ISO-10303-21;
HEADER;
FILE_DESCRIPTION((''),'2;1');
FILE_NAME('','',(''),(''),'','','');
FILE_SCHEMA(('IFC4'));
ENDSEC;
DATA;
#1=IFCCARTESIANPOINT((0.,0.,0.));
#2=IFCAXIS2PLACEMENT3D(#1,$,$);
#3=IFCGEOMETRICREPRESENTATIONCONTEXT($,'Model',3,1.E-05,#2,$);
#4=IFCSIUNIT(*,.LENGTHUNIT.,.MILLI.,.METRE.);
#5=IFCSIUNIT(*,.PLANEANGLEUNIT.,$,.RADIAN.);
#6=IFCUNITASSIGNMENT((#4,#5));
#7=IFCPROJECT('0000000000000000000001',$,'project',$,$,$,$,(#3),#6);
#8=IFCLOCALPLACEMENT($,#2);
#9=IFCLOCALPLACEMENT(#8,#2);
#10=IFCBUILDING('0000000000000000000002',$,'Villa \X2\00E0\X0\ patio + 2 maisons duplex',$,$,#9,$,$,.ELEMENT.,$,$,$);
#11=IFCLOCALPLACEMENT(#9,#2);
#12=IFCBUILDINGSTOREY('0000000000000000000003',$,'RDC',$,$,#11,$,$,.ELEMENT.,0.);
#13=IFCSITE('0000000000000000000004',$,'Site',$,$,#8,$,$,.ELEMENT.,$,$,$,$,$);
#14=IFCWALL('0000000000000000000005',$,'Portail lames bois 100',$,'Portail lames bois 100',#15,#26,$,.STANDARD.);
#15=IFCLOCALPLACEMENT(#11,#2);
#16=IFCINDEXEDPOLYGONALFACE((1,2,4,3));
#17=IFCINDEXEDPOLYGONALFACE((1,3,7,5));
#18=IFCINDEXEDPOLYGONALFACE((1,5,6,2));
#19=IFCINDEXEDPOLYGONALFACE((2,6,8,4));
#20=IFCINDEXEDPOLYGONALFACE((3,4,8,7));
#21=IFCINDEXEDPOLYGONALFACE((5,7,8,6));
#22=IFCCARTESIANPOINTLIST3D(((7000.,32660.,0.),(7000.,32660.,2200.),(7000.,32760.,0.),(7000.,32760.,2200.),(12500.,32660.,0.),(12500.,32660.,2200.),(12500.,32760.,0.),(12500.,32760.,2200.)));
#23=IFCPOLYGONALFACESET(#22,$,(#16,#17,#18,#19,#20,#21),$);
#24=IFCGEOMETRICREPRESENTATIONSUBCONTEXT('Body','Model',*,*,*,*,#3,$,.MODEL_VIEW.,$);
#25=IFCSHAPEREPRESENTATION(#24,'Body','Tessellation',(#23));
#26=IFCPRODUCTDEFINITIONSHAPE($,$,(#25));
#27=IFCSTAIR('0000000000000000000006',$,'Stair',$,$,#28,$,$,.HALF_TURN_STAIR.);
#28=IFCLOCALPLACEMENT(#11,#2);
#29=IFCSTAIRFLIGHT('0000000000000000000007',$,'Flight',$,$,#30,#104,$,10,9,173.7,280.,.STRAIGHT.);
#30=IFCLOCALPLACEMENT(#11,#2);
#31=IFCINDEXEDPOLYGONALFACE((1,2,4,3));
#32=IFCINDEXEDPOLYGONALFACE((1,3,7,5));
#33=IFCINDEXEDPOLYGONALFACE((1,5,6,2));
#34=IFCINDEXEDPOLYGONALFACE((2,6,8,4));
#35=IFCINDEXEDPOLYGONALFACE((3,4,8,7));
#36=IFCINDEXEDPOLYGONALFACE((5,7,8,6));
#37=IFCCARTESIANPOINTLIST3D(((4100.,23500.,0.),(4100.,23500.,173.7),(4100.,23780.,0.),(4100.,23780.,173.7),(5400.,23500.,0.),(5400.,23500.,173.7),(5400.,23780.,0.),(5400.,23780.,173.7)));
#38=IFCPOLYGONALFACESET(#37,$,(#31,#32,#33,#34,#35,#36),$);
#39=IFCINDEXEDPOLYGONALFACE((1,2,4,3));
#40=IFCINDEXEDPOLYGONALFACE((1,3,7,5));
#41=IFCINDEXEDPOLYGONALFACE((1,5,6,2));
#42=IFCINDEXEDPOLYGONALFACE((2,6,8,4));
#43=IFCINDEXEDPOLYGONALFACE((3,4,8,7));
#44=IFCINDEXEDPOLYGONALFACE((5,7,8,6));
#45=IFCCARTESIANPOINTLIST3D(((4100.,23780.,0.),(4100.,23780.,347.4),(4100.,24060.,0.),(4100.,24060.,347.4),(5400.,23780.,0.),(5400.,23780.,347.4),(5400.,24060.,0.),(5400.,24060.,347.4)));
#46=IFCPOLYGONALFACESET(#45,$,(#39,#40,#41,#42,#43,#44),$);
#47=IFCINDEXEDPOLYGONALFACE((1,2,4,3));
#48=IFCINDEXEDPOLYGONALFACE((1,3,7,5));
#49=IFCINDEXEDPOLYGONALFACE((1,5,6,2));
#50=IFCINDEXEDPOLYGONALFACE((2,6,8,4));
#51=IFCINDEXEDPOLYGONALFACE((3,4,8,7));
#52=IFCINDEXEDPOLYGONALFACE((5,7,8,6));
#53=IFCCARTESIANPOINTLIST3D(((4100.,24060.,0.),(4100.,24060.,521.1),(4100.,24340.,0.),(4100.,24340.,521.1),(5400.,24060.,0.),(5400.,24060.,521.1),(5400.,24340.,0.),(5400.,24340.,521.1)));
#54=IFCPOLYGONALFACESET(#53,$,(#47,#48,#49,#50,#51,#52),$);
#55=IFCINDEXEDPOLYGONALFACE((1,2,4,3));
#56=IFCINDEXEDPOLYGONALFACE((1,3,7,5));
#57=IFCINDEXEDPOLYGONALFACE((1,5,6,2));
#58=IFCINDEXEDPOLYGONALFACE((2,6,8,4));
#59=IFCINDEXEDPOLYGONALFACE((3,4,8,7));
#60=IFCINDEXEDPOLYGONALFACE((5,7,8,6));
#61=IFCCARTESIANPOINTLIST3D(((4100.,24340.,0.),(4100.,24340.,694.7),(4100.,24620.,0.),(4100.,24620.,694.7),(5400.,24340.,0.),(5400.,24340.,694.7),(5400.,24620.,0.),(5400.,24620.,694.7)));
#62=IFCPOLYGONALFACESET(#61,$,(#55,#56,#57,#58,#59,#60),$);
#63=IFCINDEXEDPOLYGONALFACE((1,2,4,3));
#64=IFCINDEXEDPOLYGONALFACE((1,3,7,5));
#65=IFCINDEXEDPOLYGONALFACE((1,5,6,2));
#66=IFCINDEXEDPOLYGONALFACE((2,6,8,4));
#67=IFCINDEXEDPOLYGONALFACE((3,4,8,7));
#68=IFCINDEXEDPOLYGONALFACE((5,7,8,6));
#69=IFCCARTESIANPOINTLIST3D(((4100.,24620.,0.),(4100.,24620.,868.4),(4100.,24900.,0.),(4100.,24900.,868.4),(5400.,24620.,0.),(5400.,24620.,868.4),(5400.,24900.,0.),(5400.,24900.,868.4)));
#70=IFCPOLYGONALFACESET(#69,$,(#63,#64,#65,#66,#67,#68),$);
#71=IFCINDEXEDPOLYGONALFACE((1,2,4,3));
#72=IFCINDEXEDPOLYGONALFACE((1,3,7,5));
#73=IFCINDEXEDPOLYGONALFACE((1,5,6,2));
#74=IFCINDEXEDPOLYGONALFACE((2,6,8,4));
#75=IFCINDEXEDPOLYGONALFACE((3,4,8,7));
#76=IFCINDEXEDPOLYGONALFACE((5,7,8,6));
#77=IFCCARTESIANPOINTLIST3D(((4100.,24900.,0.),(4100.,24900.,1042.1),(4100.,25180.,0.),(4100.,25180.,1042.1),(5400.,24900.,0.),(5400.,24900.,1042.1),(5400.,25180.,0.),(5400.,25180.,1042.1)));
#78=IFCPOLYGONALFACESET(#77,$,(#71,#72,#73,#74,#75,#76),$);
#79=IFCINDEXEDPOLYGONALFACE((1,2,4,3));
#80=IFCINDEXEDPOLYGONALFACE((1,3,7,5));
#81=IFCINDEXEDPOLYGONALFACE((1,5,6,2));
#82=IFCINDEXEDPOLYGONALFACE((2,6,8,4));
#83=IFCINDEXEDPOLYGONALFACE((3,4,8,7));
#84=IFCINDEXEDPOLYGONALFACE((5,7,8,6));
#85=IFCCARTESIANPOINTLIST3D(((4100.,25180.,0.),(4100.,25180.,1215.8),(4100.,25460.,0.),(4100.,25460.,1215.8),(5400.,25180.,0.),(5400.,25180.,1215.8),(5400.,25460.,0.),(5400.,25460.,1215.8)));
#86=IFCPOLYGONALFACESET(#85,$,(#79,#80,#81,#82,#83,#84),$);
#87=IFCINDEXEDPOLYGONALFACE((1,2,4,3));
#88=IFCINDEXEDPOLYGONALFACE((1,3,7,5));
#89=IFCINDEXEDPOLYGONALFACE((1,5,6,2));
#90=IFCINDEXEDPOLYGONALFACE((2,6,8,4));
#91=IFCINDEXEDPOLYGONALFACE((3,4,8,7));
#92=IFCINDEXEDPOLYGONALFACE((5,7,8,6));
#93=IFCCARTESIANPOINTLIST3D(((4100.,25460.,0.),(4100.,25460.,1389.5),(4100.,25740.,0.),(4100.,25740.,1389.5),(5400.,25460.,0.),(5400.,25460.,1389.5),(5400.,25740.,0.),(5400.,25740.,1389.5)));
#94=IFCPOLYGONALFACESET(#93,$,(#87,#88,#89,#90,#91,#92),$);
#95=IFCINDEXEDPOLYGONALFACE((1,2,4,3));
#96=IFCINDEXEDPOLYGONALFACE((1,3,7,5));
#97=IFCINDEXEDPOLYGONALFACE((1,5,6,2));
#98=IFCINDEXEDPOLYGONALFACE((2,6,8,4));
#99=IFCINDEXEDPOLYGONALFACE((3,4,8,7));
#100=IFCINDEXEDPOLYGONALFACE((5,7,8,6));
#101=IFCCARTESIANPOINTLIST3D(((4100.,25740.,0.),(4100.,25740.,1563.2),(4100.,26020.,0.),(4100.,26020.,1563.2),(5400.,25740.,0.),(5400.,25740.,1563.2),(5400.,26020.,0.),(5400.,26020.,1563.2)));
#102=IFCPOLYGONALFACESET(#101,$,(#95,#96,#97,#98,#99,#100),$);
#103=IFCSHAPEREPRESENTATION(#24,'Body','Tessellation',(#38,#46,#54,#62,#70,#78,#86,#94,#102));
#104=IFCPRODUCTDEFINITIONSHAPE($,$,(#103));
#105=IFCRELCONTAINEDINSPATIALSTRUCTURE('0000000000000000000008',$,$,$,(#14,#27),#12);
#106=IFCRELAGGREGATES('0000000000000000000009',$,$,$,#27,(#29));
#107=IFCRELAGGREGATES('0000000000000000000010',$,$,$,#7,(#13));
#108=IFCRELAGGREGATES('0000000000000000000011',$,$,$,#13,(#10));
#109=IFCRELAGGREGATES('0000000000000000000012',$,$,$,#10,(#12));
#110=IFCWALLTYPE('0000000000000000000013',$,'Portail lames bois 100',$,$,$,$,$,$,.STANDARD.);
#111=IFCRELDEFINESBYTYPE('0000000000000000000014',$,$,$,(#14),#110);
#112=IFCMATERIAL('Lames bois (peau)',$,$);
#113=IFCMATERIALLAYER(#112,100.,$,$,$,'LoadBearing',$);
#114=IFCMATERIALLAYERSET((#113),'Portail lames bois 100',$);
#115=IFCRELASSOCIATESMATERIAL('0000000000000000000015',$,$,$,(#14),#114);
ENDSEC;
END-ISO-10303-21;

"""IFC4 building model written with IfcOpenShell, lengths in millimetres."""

from ifc_helpers import new_model, si_unit, frame, frame_2d, origin, place, context, subcontext, project, spatial, polyline, rectangle, outline, extrude, material, layer, layer_set, layer_usage, type_object, element, aggregate, save


model = new_model("IFC4")

# Units and contexts
model_context = context("Model", 3, precision=1e-05, world=origin())
body_context = subcontext(model_context, "Body", "Model", "MODEL_VIEW")
ifc_project = project(units=[si_unit("LENGTHUNIT", "METRE", prefix="MILLI"), si_unit("PLANEANGLEUNIT", "RADIAN")], contexts=[model_context])

# Site, building, storey
site_placement = place(None, origin())
site = spatial("IfcSite", under=ifc_project, at=site_placement, Name="Site", CompositionType="ELEMENT")
building_placement = place(site_placement, origin())
building = spatial("IfcBuilding", under=site, at=building_placement, Name="Villa à patio + 2 maisons duplex", CompositionType="ELEMENT")
storey_placement = place(building_placement, origin())
storey = spatial("IfcBuildingStorey", under=building, at=storey_placement, Name="RDC", CompositionType="ELEMENT", Elevation=0.0)

# Wall
ifc_material_1 = material(Name="Lames bois (peau)")
ifc_layer_1 = layer(ifc_material_1, 100.0, Category="LoadBearing")
ifc_layer_set_1 = layer_set([ifc_layer_1], Name="Portail lames bois 100")
ifc_layer_usage_1 = layer_usage(ifc_layer_set_1, "AXIS2", "NEGATIVE", 50.0)
wall_type_1 = type_object("IfcWallType", Name="Portail lames bois 100", PredefinedType="STANDARD")
wall_1_placement = place(storey_placement, frame((7000.0, 32710.0, 0.0), z_axis=(0.0, 0.0, 1.0), x_axis=(1.0, 0.0, 0.0)))
element("IfcWall", 1, at=wall_1_placement, inside=storey, type_object=wall_type_1, material=ifc_layer_usage_1, Name="Portail lames bois 100", ObjectType="Portail lames bois 100", PredefinedType="STANDARD", context=body_context, shape_type="SweptSolid", body=[
    extrude(outline(polyline([(0.0, -50.0), (0.0, 50.0), (5500.0, 50.0), (5500.0, -50.0), (0.0, -50.0)])), origin(), (0.0, 0.0, 1.0), 2200.0),
])

# Stair, stair flight
stair_placement = place(storey_placement, origin())
stair = element("IfcStair", 2, at=stair_placement, inside=storey, Name="Stair", PredefinedType="HALF_TURN_STAIR")
stair_flight_1_placement = place(stair_placement, frame((4750.0, 23500.0, 0.0), z_axis=(0.0, 0.0, 1.0), x_axis=(0.0, 1.0, 0.0)))
stair_flight_1 = element("IfcStairFlight", 3, at=stair_flight_1_placement, Name="Flight", NumberOfRisers=10, NumberOfTreads=9, PredefinedType="STRAIGHT", RiserHeight=173.7, TreadLength=280.0, context=body_context, shape_type="SweptSolid", body=[
    extrude(rectangle(XDim=280.0, YDim=1300.0, at=frame_2d((140.0, 0.0))), origin(), (0.0, 0.0, 1.0), 173.7),
    extrude(rectangle(XDim=280.0, YDim=1300.0, at=frame_2d((420.0, 0.0))), origin(), (0.0, 0.0, 1.0), 347.4),
    extrude(rectangle(XDim=280.0, YDim=1300.0, at=frame_2d((700.0, 0.0))), origin(), (0.0, 0.0, 1.0), 521.1),
    extrude(rectangle(XDim=280.0, YDim=1300.0, at=frame_2d((980.0, 0.0))), origin(), (0.0, 0.0, 1.0), 694.7),
    extrude(rectangle(XDim=280.0, YDim=1300.0, at=frame_2d((1260.0, 0.0))), origin(), (0.0, 0.0, 1.0), 868.4),
    extrude(rectangle(XDim=280.0, YDim=1300.0, at=frame_2d((1540.0, 0.0))), origin(), (0.0, 0.0, 1.0), 1042.1),
    extrude(rectangle(XDim=280.0, YDim=1300.0, at=frame_2d((1820.0, 0.0))), origin(), (0.0, 0.0, 1.0), 1215.8),
    extrude(rectangle(XDim=280.0, YDim=1300.0, at=frame_2d((2100.0, 0.0))), origin(), (0.0, 0.0, 1.0), 1389.5),
    extrude(rectangle(XDim=280.0, YDim=1300.0, at=frame_2d((2380.0, 0.0))), origin(), (0.0, 0.0, 1.0), 1563.2),
])
aggregate(stair, [stair_flight_1])

save(model, "model.ifc")
